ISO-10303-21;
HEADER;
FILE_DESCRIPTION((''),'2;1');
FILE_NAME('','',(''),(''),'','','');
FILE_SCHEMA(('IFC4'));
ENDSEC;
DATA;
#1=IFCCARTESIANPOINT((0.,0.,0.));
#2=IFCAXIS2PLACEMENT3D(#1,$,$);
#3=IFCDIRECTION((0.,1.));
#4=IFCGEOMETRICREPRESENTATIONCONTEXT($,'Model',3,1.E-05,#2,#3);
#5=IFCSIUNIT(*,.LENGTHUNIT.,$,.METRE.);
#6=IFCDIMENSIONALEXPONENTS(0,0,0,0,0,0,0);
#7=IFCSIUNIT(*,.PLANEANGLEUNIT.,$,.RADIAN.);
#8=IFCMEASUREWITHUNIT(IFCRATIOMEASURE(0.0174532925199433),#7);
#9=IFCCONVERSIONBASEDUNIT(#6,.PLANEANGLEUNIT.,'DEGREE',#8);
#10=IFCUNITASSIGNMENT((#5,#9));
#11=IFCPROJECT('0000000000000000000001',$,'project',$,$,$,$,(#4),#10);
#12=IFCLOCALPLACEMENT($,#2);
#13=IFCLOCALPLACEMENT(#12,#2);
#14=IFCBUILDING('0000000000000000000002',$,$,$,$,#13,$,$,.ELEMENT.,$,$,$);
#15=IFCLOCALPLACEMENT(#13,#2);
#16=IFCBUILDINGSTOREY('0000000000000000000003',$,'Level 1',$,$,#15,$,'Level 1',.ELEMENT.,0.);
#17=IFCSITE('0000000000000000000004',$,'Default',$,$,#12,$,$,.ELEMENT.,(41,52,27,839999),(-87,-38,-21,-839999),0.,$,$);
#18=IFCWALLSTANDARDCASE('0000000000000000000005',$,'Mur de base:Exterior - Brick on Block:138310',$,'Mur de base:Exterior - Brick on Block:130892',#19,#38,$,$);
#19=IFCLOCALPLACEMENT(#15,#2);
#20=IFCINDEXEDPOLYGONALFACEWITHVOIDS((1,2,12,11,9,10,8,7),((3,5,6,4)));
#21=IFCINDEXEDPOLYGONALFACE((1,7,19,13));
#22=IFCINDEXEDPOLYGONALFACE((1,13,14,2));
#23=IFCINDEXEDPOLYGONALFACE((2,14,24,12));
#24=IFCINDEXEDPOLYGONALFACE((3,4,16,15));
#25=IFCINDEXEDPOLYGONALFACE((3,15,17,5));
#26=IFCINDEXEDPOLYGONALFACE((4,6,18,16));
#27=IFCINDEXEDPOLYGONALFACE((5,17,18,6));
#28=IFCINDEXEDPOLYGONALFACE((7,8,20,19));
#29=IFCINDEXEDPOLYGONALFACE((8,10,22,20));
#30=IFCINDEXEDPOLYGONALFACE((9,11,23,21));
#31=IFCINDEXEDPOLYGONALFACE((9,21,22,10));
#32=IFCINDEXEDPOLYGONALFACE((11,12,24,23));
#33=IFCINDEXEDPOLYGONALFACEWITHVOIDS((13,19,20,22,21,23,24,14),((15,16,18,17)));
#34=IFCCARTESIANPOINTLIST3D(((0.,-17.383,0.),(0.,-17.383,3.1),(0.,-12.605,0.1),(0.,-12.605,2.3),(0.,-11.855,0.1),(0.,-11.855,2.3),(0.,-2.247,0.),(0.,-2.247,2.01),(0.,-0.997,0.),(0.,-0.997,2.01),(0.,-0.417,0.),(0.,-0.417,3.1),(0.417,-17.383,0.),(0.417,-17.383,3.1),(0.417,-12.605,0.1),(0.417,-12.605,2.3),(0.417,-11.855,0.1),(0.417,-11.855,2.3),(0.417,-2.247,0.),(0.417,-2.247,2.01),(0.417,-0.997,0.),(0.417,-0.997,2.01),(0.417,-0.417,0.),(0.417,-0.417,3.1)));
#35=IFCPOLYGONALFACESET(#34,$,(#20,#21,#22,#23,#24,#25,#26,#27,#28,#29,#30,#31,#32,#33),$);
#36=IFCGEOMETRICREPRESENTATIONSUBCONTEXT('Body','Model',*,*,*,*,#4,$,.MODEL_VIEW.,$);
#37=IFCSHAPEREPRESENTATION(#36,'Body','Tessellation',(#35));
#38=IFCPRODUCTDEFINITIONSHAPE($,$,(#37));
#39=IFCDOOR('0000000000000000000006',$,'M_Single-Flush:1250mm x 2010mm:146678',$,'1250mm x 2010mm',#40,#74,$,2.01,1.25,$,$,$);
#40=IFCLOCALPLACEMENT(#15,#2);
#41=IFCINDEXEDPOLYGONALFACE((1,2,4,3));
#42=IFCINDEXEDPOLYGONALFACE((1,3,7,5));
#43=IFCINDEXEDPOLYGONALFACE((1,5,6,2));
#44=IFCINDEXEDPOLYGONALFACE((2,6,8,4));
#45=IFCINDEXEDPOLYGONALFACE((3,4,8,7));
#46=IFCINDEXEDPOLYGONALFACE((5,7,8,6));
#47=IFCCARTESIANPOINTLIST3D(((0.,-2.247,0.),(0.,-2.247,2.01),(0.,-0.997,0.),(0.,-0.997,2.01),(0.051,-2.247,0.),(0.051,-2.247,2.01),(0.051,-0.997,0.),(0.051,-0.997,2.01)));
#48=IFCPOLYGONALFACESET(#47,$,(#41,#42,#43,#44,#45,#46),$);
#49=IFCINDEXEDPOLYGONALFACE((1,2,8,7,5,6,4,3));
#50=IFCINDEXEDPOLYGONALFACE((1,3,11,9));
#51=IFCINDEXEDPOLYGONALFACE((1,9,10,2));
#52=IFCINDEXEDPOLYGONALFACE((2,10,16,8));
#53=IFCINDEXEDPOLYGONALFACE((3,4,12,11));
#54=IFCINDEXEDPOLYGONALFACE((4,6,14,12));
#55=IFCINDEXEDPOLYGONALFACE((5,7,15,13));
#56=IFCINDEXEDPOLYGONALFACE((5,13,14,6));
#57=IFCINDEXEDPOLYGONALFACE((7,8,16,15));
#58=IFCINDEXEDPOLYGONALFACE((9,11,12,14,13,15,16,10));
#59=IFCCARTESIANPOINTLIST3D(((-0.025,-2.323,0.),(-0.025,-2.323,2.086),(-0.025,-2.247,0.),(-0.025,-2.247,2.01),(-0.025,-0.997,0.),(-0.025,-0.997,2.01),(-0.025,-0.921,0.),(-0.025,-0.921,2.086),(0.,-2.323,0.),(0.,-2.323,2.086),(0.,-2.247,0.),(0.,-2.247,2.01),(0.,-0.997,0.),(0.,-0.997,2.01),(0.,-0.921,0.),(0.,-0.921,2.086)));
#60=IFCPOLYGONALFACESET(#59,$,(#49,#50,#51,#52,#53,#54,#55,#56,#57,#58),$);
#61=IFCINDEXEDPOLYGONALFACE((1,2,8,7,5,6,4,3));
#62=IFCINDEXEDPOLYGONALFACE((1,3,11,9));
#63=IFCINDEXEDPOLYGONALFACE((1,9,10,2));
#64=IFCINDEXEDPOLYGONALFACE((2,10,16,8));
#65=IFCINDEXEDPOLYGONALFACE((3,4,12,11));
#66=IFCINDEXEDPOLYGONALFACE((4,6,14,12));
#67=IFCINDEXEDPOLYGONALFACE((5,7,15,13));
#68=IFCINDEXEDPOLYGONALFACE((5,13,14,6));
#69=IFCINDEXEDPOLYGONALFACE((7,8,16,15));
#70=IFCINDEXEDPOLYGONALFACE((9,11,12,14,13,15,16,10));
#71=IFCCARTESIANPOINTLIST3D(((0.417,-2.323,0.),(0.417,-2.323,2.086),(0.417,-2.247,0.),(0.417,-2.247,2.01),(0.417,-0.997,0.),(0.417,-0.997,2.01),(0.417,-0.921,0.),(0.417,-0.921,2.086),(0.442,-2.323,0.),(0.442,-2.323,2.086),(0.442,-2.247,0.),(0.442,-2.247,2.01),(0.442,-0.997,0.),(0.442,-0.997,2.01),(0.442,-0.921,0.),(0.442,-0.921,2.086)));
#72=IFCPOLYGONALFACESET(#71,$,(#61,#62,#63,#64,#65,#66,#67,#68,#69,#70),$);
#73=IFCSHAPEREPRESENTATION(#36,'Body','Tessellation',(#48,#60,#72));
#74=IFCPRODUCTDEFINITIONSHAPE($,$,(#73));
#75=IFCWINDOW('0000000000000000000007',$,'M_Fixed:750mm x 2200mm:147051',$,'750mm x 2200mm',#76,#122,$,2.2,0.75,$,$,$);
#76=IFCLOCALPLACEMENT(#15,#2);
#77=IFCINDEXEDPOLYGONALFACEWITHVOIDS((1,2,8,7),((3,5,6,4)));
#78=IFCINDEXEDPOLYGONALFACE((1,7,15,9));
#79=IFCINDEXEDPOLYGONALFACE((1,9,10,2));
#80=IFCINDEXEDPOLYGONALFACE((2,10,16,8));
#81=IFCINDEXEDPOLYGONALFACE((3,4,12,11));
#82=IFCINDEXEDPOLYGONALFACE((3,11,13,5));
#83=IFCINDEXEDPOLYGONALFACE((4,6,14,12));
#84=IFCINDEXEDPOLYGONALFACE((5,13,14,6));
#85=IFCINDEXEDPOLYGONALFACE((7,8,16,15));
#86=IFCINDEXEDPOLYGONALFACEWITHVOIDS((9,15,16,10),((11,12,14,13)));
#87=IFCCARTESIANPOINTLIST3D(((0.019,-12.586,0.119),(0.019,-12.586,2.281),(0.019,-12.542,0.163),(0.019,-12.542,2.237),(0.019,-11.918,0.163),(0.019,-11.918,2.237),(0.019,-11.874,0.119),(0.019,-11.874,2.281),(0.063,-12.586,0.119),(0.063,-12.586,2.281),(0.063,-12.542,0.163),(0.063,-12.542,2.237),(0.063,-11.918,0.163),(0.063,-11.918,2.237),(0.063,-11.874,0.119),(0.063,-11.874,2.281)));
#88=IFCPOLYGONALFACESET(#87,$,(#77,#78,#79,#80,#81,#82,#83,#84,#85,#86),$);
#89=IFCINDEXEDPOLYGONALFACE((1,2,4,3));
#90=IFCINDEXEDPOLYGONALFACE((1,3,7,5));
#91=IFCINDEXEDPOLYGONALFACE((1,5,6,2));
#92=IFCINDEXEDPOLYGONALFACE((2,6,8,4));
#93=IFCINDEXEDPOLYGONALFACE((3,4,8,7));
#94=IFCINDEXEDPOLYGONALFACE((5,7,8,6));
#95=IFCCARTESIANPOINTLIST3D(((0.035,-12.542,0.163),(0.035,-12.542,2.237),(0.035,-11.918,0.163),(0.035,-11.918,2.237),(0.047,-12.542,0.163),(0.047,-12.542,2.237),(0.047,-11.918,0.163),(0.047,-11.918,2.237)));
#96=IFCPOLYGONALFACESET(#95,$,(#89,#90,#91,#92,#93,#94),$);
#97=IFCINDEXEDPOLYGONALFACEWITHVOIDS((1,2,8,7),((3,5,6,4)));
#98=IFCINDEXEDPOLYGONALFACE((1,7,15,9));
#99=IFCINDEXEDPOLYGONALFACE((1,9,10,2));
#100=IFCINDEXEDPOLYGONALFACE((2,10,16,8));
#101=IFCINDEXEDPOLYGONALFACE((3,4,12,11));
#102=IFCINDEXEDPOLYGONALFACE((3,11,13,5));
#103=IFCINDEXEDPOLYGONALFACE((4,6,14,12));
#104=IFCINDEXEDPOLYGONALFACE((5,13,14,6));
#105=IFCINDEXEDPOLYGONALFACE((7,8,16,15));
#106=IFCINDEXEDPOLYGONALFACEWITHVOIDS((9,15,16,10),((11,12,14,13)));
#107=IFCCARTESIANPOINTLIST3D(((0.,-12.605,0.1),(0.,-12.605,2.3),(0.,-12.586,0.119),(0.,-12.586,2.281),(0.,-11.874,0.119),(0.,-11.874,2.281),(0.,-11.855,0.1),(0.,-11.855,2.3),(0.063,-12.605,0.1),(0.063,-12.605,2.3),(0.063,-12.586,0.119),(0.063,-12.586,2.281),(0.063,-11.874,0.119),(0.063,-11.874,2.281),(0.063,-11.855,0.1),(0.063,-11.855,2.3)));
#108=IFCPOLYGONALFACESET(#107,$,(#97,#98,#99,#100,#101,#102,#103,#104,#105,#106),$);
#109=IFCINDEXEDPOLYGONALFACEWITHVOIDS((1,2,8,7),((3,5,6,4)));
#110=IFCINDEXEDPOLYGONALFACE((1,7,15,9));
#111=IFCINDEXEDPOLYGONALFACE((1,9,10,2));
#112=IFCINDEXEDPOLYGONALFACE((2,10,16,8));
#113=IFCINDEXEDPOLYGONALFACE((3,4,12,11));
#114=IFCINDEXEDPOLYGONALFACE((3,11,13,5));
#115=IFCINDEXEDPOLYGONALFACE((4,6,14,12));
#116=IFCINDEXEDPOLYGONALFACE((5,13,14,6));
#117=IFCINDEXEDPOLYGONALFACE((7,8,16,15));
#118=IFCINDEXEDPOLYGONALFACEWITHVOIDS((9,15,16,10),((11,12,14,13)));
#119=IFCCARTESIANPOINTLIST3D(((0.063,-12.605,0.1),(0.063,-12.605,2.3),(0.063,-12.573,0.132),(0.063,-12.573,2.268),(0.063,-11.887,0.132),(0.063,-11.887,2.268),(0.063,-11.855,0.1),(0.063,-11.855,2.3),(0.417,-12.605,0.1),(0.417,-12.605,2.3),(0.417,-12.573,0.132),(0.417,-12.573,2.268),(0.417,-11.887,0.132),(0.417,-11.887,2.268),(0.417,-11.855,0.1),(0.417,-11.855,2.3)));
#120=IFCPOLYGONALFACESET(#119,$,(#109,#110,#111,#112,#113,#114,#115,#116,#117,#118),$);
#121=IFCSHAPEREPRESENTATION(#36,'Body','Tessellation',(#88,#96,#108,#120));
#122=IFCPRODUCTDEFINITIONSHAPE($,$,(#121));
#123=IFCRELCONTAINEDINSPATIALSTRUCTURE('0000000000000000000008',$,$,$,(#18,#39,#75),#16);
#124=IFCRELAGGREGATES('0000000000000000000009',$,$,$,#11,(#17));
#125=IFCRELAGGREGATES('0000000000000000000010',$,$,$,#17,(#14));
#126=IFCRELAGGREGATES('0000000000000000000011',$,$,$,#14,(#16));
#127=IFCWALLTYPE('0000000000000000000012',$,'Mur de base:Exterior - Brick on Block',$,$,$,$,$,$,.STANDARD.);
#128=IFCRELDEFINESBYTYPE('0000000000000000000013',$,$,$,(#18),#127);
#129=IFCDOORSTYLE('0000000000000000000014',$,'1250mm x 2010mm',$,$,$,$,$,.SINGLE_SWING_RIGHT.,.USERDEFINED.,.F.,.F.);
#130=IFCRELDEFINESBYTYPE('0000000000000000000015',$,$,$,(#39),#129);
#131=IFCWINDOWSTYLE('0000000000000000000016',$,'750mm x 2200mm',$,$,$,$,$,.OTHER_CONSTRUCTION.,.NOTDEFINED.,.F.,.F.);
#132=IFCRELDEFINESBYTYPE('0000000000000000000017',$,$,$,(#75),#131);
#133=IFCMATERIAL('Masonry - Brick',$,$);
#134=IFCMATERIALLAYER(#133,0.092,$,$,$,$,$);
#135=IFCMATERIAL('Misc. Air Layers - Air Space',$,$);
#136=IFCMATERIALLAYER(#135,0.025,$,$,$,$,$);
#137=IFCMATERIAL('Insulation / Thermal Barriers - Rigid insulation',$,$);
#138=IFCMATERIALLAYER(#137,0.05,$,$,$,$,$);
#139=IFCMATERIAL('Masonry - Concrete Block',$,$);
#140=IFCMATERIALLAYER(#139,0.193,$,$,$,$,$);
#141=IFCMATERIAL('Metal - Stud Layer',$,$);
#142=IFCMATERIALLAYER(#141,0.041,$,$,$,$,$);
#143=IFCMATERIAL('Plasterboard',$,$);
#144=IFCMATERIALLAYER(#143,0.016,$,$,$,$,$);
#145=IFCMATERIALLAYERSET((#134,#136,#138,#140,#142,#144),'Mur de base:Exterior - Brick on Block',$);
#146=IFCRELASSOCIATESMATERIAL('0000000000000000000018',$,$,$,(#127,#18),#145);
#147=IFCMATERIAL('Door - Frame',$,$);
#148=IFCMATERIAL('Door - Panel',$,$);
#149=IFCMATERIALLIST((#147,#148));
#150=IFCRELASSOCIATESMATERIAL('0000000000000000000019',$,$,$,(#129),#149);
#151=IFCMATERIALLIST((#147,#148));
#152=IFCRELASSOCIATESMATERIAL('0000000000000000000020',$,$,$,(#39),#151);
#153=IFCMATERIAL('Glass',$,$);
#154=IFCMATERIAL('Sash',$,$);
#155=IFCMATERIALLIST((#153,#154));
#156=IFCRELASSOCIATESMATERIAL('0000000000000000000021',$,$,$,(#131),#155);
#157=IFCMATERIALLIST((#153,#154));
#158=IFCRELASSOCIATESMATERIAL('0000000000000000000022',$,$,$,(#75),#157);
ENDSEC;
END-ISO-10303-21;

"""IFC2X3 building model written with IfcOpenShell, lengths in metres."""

from ifc_helpers import new_model, entity, si_unit, converted_unit, direction, frame, frame_2d, origin, origin_2d_with_axis, place, context, subcontext, project, spatial, polyline, rectangle, outline, extrude, source, transform, mapped, material, material_list, layer, layer_set, layer_usage, type_object, type_shapes, element, fill, save


model = new_model("IFC2X3")

# Units and contexts
model_context = context("Model", 3, precision=1e-05, world=origin(), true_north=direction((0.0, 1.0)))
body_context = subcontext(model_context, "Body", "Model", "MODEL_VIEW")
ifc_project = project(units=[si_unit("LENGTHUNIT", "METRE"), converted_unit("PLANEANGLEUNIT", "DEGREE", entity("IfcRatioMeasure", 0.0174532925199433), si_unit("PLANEANGLEUNIT", "RADIAN"), dimensions=[0, 0, 0, 0, 0, 0, 0])], contexts=[model_context])

# Site, building, storey
site_placement = place(None, origin())
site = spatial("IfcSite", under=ifc_project, at=site_placement, Name="Default", CompositionType="ELEMENT", RefLatitude=(41, 52, 27, 839999), RefLongitude=(-87, -38, -21, -839999), RefElevation=0.0)
building_placement = place(site_placement, origin())
building = spatial("IfcBuilding", under=site, at=building_placement, CompositionType="ELEMENT")
storey_placement = place(building_placement, origin())
storey = spatial("IfcBuildingStorey", under=building, at=storey_placement, Name="Level 1", LongName="Level 1", CompositionType="ELEMENT", Elevation=0.0)

# Shared definitions
ifc_material_1 = material(Name="Masonry - Brick")
ifc_layer_1 = layer(ifc_material_1, 0.092)
ifc_material_2 = material(Name="Misc. Air Layers - Air Space")
ifc_layer_2 = layer(ifc_material_2, 0.025)
ifc_material_3 = material(Name="Insulation / Thermal Barriers - Rigid insulation")
ifc_layer_3 = layer(ifc_material_3, 0.05)
ifc_material_4 = material(Name="Masonry - Concrete Block")
ifc_layer_4 = layer(ifc_material_4, 0.193)
ifc_material_5 = material(Name="Metal - Stud Layer")
ifc_layer_5 = layer(ifc_material_5, 0.041)
ifc_material_6 = material(Name="Plasterboard")
ifc_layer_6 = layer(ifc_material_6, 0.016)
ifc_layer_set_1 = layer_set([ifc_layer_1, ifc_layer_2, ifc_layer_3, ifc_layer_4, ifc_layer_5, ifc_layer_6], Name="Mur de base:Exterior - Brick on Block")
wall_type_1 = type_object("IfcWallType", Name="Mur de base:Exterior - Brick on Block", PredefinedType="STANDARD", material=ifc_layer_set_1)
ifc_material_7 = material(Name="Glass")
ifc_material_8 = material(Name="Sash")
ifc_material_9 = material(Name="Door - Frame")
ifc_material_10 = material(Name="Door - Panel")

# Wall, openings, door, window
ifc_layer_usage_1 = layer_usage(ifc_layer_set_1, "AXIS2", "NEGATIVE", 0.2085)
wall_1_placement = place(storey_placement, frame((0.2085, -17.383, 0.0), z_axis=(0.0, 0.0, 1.0), x_axis=(0.0, 1.0, 0.0)))
wall_1 = element("IfcWallStandardCase", 1, at=wall_1_placement, inside=storey, type_object=wall_type_1, material=ifc_layer_usage_1, Name="Mur de base:Exterior - Brick on Block:138310", ObjectType="Mur de base:Exterior - Brick on Block:130892", context=body_context, shape_type="SweptSolid", body=[
    extrude(rectangle(XDim=16.966, YDim=0.417, at=frame_2d((8.483, 0.0), x_axis=(-1.0, 0.0))), origin(), (0.0, 0.0, 1.0), 3.1),
])
opening_1_placement = place(wall_1_placement, frame((15.136, -0.2085, 0.0)))
opening_1 = element("IfcOpeningElement", 2, at=opening_1_placement, cuts=wall_1, ObjectType="Opening", context=body_context, shape_type="SweptSolid", body=[
    extrude(rectangle(XDim=1.25, YDim=2.01, at=frame_2d((1.005, 0.625), x_axis=(0.0, 1.0))), frame((0.0, 0.0, 0.0), z_axis=(0.0, 1.0, 0.0), x_axis=(0.0, 0.0, 1.0)), (0.0, 0.0, 1.0), 0.417),
])
opening_2_placement = place(wall_1_placement, frame((4.778, -0.2085, 0.1)))
opening_2 = element("IfcOpeningElement", 3, at=opening_2_placement, cuts=wall_1, ObjectType="Opening", context=body_context, shape_type="SweptSolid", body=[
    extrude(rectangle(XDim=2.2, YDim=0.75, at=frame_2d((1.1, 0.375), x_axis=(1.0, 0.0))), frame((0.0, 0.0, 0.0), z_axis=(0.0, 1.0, 0.0), x_axis=(0.0, 0.0, 1.0)), (0.0, 0.0, 1.0), 0.417),
])
ifc_material_list_1 = material_list([ifc_material_9, ifc_material_10])
ifc_material_list_2 = material_list([ifc_material_9, ifc_material_10])
door_style_1 = type_object("IfcDoorStyle", Name="1250mm x 2010mm", ConstructionType="USERDEFINED", OperationType="SINGLE_SWING_RIGHT", ParameterTakesPrecedence=False, Sizeable=False, material=ifc_material_list_2)
shared_shape_1 = source(origin(), body_context, "Body", "SweptSolid", [
    extrude(rectangle(XDim=0.051, YDim=1.25, at=frame_2d((0.0, 0.0), x_axis=(1.0, 0.0))), frame((0.625, 0.3915, 0.0), z_axis=(0.0, 0.0, 1.0), x_axis=(0.0, 1.0, 0.0)), (0.0, 0.0, 1.0), 2.01),
    extrude(outline(polyline([(-0.701, -1.062), (0.701, -1.062), (0.701, 1.024), (0.625, 1.024), (0.625, -0.986), (-0.625, -0.986), (-0.625, 1.024), (-0.701, 1.024), (-0.701, -1.062)])), frame((0.625, 0.417, 1.024), z_axis=(0.0, 1.0, 0.0), x_axis=(1.0, 0.0, 0.0)), (0.0, 0.0, 1.0), 0.025),
    extrude(outline(polyline([(-1.062, -0.701), (1.024, -0.701), (1.024, -0.625), (-0.986, -0.625), (-0.986, 0.625), (1.024, 0.625), (1.024, 0.701), (-1.062, 0.701), (-1.062, -0.701)])), frame((0.625, -0.025, 1.024), z_axis=(0.0, 1.0, 0.0), x_axis=(0.0, 0.0, -1.0)), (0.0, 0.0, 1.0), 0.025),
])
type_shapes(door_style_1, [shared_shape_1])
door_1_placement = place(opening_1_placement, origin())
door_1 = element("IfcDoor", 4, at=door_1_placement, inside=storey, type_object=door_style_1, material=ifc_material_list_1, Name="M_Single-Flush:1250mm x 2010mm:146678", ObjectType="1250mm x 2010mm", OverallHeight=2.01, OverallWidth=1.25, context=body_context, shape_type="MappedRepresentation", body=[
    mapped(shared_shape_1, transform((0.0, 0.0, 0.0), scale=1.0)),
])
fill(opening_1, door_1)
ifc_material_list_3 = material_list([ifc_material_7, ifc_material_8])
ifc_material_list_4 = material_list([ifc_material_7, ifc_material_8])
window_style_1 = type_object("IfcWindowStyle", Name="750mm x 2200mm", ConstructionType="OTHER_CONSTRUCTION", OperationType="NOTDEFINED", ParameterTakesPrecedence=False, Sizeable=False, material=ifc_material_list_4)
shared_shape_2 = source(origin(), body_context, "Body", "SweptSolid", [
    extrude(outline(polyline([(-0.356, -1.081), (0.356, -1.081), (0.356, 1.081), (-0.356, 1.081), (-0.356, -1.081)]), holes=[polyline([(-0.312, -1.037), (-0.312, 1.037), (0.312, 1.037), (0.312, -1.037), (-0.312, -1.037)])]), frame((0.375, 0.354, 1.1), z_axis=(0.0, 1.0, 0.0), x_axis=(1.0, 0.0, 0.0)), (0.0, 0.0, 1.0), 0.044),
    extrude(rectangle(XDim=0.012, YDim=0.624, at=origin_2d_with_axis()), frame((0.375, 0.376, 0.063), z_axis=(0.0, 0.0, 1.0), x_axis=(0.0, -1.0, 0.0)), (0.0, 0.0, 1.0), 2.074),
    extrude(outline(polyline([(-0.375, -1.1), (0.375, -1.1), (0.375, 1.1), (-0.375, 1.1), (-0.375, -1.1)]), holes=[polyline([(-0.356, -1.081), (-0.356, 1.081), (0.356, 1.081), (0.356, -1.081), (-0.356, -1.081)])]), frame((0.375, 0.354, 1.1), z_axis=(0.0, 1.0, 0.0), x_axis=(1.0, 0.0, 0.0)), (0.0, 0.0, 1.0), 0.063),
    extrude(outline(polyline([(-0.375, -1.1), (0.375, -1.1), (0.375, 1.1), (-0.375, 1.1), (-0.375, -1.1)]), holes=[polyline([(-0.343, -1.068), (-0.343, 1.068), (0.343, 1.068), (0.343, -1.068), (-0.343, -1.068)])]), frame((0.375, 0.0, 1.1), z_axis=(0.0, 1.0, 0.0), x_axis=(1.0, 0.0, 0.0)), (0.0, 0.0, 1.0), 0.354),
])
type_shapes(window_style_1, [shared_shape_2])
window_1_placement = place(opening_2_placement, origin())
window_1 = element("IfcWindow", 5, at=window_1_placement, inside=storey, type_object=window_style_1, material=ifc_material_list_3, Name="M_Fixed:750mm x 2200mm:147051", ObjectType="750mm x 2200mm", OverallHeight=2.2, OverallWidth=0.75, context=body_context, shape_type="MappedRepresentation", body=[
    mapped(shared_shape_2, transform((0.0, 0.0, 0.0), scale=1.0)),
])
fill(opening_2, window_1)

save(model, "model.ifc")
